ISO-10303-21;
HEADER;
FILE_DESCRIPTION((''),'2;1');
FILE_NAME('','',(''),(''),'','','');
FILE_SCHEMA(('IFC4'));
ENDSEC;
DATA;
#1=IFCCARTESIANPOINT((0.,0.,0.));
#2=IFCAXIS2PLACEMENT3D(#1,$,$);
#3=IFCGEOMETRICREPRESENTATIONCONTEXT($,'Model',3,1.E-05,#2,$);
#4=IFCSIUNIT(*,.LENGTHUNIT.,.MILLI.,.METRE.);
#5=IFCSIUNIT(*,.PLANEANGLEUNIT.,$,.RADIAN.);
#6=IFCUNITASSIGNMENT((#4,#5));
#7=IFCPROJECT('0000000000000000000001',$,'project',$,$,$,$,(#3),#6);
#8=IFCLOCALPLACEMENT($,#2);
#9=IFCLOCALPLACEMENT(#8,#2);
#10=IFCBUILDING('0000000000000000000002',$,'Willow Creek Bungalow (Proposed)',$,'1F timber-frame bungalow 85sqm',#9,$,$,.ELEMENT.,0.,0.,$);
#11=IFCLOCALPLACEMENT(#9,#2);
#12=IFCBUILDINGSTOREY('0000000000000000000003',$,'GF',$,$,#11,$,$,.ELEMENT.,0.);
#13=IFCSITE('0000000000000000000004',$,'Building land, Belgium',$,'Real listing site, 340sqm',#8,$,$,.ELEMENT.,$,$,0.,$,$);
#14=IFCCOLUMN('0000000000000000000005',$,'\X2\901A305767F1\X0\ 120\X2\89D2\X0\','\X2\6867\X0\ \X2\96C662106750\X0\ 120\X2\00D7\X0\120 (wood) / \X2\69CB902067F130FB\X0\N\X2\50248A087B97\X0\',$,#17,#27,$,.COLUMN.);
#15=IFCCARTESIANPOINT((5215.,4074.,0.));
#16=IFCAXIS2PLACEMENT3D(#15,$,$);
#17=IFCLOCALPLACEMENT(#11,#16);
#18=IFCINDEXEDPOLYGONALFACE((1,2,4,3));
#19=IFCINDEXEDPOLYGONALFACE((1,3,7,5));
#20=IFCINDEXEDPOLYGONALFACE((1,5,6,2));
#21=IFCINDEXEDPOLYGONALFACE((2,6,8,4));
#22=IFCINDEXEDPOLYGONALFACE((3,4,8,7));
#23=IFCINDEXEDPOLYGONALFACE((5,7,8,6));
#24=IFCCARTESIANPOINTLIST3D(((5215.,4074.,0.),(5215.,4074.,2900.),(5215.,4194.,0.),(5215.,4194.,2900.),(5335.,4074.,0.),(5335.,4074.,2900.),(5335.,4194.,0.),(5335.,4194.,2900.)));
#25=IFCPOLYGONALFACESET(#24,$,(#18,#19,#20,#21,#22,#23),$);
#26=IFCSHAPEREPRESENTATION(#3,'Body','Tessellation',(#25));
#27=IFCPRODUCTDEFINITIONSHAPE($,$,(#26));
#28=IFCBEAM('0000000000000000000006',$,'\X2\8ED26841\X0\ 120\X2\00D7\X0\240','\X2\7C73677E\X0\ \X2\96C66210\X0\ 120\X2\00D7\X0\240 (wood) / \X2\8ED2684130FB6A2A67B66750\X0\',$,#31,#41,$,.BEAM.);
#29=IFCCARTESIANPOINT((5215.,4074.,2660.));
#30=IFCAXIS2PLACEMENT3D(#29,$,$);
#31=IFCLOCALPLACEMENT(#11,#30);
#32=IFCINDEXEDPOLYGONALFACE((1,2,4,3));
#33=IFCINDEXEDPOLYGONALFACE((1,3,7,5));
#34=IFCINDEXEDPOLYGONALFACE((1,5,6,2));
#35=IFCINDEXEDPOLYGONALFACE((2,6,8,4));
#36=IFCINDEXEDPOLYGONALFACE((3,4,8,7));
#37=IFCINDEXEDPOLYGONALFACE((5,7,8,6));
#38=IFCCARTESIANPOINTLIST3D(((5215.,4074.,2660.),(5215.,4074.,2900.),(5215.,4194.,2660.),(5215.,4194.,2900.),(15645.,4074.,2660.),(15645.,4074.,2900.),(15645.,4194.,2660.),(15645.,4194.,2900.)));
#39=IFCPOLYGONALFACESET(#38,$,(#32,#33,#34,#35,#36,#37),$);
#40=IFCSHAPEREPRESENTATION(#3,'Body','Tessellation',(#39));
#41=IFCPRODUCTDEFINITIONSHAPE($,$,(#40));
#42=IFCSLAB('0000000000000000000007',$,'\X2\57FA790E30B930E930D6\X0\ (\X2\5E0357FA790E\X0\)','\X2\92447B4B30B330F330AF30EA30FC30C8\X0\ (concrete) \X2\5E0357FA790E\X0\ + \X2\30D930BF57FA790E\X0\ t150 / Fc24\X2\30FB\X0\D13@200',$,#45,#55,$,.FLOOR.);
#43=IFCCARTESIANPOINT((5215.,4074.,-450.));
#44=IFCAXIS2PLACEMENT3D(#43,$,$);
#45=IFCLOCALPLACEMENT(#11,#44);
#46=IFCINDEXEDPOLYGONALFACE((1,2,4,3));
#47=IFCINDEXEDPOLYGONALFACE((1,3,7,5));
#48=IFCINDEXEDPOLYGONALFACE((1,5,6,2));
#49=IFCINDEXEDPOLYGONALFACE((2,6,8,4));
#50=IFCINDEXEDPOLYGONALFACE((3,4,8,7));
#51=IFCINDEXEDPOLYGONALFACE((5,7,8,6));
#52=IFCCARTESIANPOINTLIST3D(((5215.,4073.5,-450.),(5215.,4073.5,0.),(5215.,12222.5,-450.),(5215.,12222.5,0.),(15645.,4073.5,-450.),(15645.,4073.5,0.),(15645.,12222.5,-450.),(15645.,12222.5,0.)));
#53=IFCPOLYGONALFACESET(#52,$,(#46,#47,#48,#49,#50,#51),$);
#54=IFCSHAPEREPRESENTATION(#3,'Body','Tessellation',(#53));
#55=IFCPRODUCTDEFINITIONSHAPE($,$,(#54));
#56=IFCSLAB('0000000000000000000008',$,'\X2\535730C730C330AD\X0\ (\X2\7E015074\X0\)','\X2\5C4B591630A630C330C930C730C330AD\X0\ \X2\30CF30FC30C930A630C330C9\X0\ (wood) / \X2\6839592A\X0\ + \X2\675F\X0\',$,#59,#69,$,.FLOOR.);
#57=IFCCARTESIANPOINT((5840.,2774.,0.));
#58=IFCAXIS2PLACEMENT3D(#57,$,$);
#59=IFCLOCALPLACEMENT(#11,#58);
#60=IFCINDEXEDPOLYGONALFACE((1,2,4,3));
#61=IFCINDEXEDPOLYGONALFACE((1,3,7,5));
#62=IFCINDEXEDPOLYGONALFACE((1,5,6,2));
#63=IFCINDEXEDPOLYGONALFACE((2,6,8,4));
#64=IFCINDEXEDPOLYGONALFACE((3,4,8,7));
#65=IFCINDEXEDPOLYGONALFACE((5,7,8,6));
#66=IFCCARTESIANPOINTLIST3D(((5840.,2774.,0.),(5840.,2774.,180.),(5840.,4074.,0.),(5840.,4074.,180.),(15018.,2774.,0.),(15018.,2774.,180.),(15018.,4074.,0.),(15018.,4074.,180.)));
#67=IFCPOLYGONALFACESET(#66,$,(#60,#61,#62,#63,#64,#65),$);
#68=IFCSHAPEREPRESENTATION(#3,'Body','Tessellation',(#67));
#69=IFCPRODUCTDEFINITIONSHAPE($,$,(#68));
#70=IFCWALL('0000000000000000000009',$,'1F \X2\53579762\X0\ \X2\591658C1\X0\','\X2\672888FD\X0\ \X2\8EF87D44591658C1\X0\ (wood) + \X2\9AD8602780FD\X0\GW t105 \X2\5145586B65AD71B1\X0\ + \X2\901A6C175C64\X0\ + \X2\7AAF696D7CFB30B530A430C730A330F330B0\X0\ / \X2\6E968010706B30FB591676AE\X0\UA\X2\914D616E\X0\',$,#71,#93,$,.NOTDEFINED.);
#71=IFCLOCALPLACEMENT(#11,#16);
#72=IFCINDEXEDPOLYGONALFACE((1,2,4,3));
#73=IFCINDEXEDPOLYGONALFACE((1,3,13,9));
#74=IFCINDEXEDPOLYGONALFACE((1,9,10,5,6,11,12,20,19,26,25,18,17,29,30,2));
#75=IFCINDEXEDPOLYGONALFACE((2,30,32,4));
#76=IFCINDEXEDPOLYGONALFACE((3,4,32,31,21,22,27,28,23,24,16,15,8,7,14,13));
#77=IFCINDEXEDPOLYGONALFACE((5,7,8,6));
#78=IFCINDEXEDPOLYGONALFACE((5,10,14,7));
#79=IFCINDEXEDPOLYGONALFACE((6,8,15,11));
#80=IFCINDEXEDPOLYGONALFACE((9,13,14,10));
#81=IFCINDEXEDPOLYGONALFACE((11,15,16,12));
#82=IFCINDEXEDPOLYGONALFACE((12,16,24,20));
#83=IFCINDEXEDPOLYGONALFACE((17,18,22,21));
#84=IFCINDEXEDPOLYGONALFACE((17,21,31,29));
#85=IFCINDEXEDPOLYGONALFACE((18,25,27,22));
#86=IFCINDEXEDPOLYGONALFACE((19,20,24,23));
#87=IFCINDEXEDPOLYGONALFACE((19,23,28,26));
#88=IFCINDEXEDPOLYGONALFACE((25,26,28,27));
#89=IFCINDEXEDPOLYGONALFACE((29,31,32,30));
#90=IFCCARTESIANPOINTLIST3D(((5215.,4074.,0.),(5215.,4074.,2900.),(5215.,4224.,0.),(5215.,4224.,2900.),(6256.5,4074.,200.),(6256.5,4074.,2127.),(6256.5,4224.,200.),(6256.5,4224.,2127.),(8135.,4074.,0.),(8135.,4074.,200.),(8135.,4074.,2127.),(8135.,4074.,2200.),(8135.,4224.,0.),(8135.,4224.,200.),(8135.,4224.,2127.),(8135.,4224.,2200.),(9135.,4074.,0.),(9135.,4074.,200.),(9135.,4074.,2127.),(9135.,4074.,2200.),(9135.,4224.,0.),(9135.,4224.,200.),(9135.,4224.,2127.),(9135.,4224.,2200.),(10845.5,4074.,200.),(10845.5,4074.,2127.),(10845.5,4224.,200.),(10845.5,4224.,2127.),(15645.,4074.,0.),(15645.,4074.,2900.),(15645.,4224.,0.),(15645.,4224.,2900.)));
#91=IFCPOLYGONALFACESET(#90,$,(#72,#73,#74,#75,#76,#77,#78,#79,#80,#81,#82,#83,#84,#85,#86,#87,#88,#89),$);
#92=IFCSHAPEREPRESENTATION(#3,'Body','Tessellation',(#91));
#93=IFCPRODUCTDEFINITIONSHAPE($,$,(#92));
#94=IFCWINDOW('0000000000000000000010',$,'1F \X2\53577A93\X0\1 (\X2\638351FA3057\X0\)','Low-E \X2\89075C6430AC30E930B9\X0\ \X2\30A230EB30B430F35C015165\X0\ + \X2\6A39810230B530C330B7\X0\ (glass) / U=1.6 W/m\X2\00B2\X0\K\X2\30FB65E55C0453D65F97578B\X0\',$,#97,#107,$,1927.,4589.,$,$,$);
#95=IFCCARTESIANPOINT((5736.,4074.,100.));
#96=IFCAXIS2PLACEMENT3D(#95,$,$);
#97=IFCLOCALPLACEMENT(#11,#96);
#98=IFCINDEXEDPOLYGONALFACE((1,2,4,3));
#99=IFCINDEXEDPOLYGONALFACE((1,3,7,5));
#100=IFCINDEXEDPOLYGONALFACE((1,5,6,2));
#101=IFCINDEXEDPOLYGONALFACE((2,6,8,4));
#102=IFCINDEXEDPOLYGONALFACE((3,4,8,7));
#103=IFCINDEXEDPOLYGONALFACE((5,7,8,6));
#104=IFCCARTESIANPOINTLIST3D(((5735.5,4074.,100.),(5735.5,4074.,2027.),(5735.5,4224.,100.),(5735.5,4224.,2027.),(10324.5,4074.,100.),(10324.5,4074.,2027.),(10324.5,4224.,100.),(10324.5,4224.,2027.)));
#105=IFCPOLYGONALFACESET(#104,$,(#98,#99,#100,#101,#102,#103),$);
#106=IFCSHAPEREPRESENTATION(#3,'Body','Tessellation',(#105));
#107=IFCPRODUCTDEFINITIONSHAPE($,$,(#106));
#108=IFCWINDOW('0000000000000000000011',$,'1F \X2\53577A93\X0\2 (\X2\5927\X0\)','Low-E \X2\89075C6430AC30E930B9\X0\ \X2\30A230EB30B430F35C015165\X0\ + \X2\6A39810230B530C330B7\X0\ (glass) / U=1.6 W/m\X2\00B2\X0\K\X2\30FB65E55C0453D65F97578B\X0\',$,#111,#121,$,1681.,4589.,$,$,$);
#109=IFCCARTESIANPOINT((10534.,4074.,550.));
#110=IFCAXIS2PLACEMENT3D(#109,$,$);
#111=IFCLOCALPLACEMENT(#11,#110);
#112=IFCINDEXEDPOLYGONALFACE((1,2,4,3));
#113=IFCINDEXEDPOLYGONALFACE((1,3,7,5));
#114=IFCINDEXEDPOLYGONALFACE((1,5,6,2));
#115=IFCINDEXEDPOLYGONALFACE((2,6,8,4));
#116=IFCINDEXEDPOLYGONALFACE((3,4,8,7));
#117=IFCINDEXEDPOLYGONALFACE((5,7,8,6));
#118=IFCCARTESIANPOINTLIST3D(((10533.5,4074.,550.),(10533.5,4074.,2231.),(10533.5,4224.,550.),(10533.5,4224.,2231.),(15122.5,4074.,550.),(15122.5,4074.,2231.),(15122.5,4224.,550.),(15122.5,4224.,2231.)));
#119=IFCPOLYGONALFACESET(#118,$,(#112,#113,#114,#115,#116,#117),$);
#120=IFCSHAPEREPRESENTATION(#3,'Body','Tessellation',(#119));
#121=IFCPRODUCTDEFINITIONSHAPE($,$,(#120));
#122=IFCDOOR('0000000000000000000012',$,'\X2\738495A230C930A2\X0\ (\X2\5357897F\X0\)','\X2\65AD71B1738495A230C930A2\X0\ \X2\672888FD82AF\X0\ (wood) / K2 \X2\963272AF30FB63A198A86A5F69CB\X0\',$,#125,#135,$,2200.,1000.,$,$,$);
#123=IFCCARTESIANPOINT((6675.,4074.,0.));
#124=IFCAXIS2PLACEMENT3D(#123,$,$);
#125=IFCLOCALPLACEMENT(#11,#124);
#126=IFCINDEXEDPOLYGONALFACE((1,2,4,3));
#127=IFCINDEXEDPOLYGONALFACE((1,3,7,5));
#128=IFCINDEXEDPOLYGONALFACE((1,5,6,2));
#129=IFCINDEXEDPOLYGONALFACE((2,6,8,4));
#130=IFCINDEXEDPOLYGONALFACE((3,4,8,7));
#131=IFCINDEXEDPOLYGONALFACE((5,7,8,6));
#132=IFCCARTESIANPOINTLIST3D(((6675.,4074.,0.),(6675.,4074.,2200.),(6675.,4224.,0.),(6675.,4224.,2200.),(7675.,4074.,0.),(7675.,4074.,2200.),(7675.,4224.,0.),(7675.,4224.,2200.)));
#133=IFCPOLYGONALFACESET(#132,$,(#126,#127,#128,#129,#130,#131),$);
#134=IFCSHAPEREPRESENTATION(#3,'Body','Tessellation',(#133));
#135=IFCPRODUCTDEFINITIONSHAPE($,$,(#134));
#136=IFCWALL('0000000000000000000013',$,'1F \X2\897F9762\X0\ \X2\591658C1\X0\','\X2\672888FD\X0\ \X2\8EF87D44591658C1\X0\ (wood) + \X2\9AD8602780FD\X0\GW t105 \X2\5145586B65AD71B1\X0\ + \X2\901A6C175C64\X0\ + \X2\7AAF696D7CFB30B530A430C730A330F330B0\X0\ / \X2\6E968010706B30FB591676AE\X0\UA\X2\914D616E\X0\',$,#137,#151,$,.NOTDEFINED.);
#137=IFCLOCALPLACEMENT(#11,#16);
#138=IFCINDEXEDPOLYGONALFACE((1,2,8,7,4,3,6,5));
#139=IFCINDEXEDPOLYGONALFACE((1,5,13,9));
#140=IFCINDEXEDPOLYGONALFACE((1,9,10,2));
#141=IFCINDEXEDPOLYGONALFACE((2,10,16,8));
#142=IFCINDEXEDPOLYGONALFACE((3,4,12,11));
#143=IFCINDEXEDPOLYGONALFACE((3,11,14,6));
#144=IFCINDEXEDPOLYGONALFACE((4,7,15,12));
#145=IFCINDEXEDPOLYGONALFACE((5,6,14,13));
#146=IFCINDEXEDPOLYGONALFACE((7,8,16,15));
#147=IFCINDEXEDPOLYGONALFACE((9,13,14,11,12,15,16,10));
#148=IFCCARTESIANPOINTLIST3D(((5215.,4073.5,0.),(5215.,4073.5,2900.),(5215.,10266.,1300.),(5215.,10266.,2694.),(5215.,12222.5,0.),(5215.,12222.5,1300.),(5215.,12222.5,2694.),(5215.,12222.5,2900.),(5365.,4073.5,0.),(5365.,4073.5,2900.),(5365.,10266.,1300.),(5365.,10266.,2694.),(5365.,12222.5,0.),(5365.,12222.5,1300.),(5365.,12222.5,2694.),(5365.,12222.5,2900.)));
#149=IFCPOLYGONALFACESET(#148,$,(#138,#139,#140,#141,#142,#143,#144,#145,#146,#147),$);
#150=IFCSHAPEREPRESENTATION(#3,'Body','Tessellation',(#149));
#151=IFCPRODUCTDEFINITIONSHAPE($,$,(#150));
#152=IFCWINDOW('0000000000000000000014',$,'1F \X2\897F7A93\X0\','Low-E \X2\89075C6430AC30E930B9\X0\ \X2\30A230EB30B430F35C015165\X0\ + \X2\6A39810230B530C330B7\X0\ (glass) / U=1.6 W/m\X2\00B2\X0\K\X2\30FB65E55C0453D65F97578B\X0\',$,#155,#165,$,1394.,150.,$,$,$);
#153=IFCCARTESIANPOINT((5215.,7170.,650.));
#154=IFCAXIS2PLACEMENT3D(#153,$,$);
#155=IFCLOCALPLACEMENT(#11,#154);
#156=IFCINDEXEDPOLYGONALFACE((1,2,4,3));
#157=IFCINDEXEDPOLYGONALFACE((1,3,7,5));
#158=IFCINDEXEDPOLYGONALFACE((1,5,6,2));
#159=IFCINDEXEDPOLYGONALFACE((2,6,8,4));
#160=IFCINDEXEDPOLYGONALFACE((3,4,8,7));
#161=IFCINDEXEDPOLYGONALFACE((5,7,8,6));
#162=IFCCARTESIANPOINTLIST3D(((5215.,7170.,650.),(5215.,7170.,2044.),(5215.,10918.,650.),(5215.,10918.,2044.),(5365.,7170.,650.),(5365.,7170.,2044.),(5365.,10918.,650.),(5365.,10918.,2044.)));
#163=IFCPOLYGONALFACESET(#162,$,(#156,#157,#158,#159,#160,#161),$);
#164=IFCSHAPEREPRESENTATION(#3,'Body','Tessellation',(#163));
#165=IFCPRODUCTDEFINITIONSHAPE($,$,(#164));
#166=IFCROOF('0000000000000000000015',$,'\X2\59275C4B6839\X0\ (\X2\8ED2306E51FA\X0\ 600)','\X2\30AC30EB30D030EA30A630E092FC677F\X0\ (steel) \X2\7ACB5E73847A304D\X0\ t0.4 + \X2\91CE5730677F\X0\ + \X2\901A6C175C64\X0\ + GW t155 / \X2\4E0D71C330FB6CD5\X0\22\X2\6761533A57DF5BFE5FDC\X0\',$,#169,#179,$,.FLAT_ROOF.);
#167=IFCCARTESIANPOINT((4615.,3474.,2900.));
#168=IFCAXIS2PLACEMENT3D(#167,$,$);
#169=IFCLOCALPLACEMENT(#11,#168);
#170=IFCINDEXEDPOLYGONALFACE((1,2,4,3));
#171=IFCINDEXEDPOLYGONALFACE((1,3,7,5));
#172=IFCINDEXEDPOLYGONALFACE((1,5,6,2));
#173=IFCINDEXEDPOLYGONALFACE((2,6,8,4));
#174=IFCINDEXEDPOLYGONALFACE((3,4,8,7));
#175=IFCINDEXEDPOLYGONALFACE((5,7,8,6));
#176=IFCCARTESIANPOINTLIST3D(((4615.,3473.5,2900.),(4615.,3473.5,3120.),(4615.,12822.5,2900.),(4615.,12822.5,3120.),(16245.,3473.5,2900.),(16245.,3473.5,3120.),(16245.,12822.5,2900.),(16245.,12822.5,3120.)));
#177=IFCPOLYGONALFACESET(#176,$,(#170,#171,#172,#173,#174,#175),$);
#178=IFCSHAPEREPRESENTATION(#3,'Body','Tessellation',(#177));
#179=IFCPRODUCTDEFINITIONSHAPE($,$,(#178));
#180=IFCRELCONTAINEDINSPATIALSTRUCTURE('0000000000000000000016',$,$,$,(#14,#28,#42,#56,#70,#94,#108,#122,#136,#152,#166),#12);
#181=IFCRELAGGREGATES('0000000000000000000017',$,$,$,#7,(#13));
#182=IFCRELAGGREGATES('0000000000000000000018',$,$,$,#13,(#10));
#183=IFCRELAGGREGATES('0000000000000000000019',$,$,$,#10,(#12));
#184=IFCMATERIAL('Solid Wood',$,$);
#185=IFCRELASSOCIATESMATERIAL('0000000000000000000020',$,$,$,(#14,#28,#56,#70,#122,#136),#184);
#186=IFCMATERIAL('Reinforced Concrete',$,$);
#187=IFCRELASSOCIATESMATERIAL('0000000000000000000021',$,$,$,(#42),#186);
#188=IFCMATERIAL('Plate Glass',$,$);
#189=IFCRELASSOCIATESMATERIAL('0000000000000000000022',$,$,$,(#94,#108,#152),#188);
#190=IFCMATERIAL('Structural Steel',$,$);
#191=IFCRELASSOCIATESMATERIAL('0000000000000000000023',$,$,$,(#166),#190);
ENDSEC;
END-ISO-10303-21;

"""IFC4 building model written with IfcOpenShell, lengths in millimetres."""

from ifc_helpers import new_model, si_unit, frame, frame_2d, origin, place, context, project, spatial, rectangle, extrude, material, element, fill, save


model = new_model("IFC4")

# Units and contexts
model_context = context("Model", 3, precision=1e-05, world=origin())
ifc_project = project(units=[si_unit("LENGTHUNIT", "METRE", prefix="MILLI"), si_unit("PLANEANGLEUNIT", "RADIAN")], contexts=[model_context])

# Site, building, storey
site_placement = place(None, origin())
site = spatial("IfcSite", under=ifc_project, at=site_placement, Name="Building land, Belgium", ObjectType="Real listing site, 340sqm", CompositionType="ELEMENT", RefElevation=0.0)
building_placement = place(site_placement, origin())
building = spatial("IfcBuilding", under=site, at=building_placement, Name="Willow Creek Bungalow (Proposed)", ObjectType="1F timber-frame bungalow 85sqm", CompositionType="ELEMENT", ElevationOfRefHeight=0.0, ElevationOfTerrain=0.0)
storey_placement = place(building_placement, origin())
storey = spatial("IfcBuildingStorey", under=building, at=storey_placement, Name="GF", CompositionType="ELEMENT", Elevation=0.0)

# Column
ifc_material_1 = material(Name="Solid Wood")
column_1_placement = place(storey_placement, frame((5215.0, 4074.0, 0.0)))
element("IfcColumn", 1, at=column_1_placement, inside=storey, material=ifc_material_1, Name="通し柱 120角", Description="桧 集成材 120×120 (wood) / 構造柱・N値計算", PredefinedType="COLUMN", context=model_context, shape_type="SweptSolid", body=[
    extrude(rectangle(XDim=120.0, YDim=120.0, at=frame_2d((60.0, 60.0))), frame((5215.0, 4074.0, 0.0)), (0.0, 0.0, 1.0), 2900.0),
])

# Beam
beam_1_placement = place(storey_placement, frame((5215.0, 4074.0, 2660.0)))
element("IfcBeam", 2, at=beam_1_placement, inside=storey, material=ifc_material_1, Name="軒桁 120×240", Description="米松 集成 120×240 (wood) / 軒桁・横架材", PredefinedType="BEAM", context=model_context, shape_type="SweptSolid", body=[
    extrude(rectangle(XDim=10430.0, YDim=120.0, at=frame_2d((5215.0, 60.0))), frame((5215.0, 4074.0, 2660.0)), (0.0, 0.0, 1.0), 240.0),
])

# Slabs
ifc_material_2 = material(Name="Reinforced Concrete")
slab_1_placement = place(storey_placement, frame((5215.0, 4074.0, -450.0)))
element("IfcSlab", 3, at=slab_1_placement, inside=storey, material=ifc_material_2, Name="基礎スラブ (布基礎)", Description="鉄筋コンクリート (concrete) 布基礎 + ベタ基礎 t150 / Fc24・D13@200", PredefinedType="FLOOR", context=model_context, shape_type="SweptSolid", body=[
    extrude(rectangle(XDim=10430.0, YDim=8149.0, at=frame_2d((5215.0, 4074.0))), frame((5215.0, 4074.0, -450.0)), (0.0, 0.0, 1.0), 450.0),
])
slab_2_placement = place(storey_placement, frame((5840.0, 2774.0, 0.0)))
element("IfcSlab", 4, at=slab_2_placement, inside=storey, material=ifc_material_1, Name="南デッキ (縁側)", Description="屋外ウッドデッキ ハードウッド (wood) / 根太 + 束", PredefinedType="FLOOR", context=model_context, shape_type="SweptSolid", body=[
    extrude(rectangle(XDim=9178.0, YDim=1300.0, at=frame_2d((4589.0, 650.0))), frame((5840.0, 2774.0, 0.0)), (0.0, 0.0, 1.0), 180.0),
])

# Wall, openings, windows, door
wall_1_placement = place(storey_placement, frame((5215.0, 4074.0, 0.0)))
wall_1 = element("IfcWall", 5, at=wall_1_placement, inside=storey, material=ifc_material_1, Name="1F 南面 外壁", Description="木製 軸組外壁 (wood) + 高性能GW t105 充填断熱 + 通気層 + 窯業系サイディング / 準耐火・外皮UA配慮", PredefinedType="NOTDEFINED", context=model_context, shape_type="SweptSolid", body=[
    extrude(rectangle(XDim=10430.0, YDim=150.0, at=frame_2d((5215.0, 75.0))), frame((5215.0, 4074.0, 0.0)), (0.0, 0.0, 1.0), 2900.0),
])
opening_1_placement = place(storey_placement, frame((5736.0, 4074.0, 100.0)))
opening_1 = element("IfcOpeningElement", 6, at=opening_1_placement, cuts=wall_1, PredefinedType="NOTDEFINED", context=model_context, shape_type="SweptSolid", body=[
    extrude(rectangle(XDim=4589.0, YDim=150.0, at=frame_2d((2294.0, 75.0))), frame((5736.0, 4074.0, 100.0)), (0.0, 0.0, 1.0), 1927.0),
])
opening_2_placement = place(storey_placement, frame((10534.0, 4074.0, 550.0)))
opening_2 = element("IfcOpeningElement", 7, at=opening_2_placement, cuts=wall_1, PredefinedType="NOTDEFINED", context=model_context, shape_type="SweptSolid", body=[
    extrude(rectangle(XDim=4589.0, YDim=150.0, at=frame_2d((2294.0, 75.0))), frame((10534.0, 4074.0, 550.0)), (0.0, 0.0, 1.0), 1681.0),
])
opening_3_placement = place(storey_placement, frame((6675.0, 4074.0, 0.0)))
opening_3 = element("IfcOpeningElement", 8, at=opening_3_placement, cuts=wall_1, PredefinedType="NOTDEFINED", context=model_context, shape_type="SweptSolid", body=[
    extrude(rectangle(XDim=1000.0, YDim=150.0, at=frame_2d((500.0, 75.0))), frame((6675.0, 4074.0, 0.0)), (0.0, 0.0, 1.0), 2200.0),
])
ifc_material_3 = material(Name="Plate Glass")
window_1_placement = place(storey_placement, frame((5736.0, 4074.0, 100.0)))
window_1 = element("IfcWindow", 9, at=window_1_placement, inside=storey, material=ifc_material_3, Name="1F 南窓1 (掃出し)", Description="Low-E 複層ガラス アルゴン封入 + 樹脂サッシ (glass) / U=1.6 W/m²K・日射取得型", OverallHeight=1927.0, OverallWidth=4589.0, context=model_context, shape_type="SweptSolid", body=[
    extrude(rectangle(XDim=4589.0, YDim=150.0, at=frame_2d((2294.0, 75.0))), frame((5736.0, 4074.0, 100.0)), (0.0, 0.0, 1.0), 1927.0),
])
fill(opening_1, window_1)
window_2_placement = place(storey_placement, frame((10534.0, 4074.0, 550.0)))
window_2 = element("IfcWindow", 10, at=window_2_placement, inside=storey, material=ifc_material_3, Name="1F 南窓2 (大)", Description="Low-E 複層ガラス アルゴン封入 + 樹脂サッシ (glass) / U=1.6 W/m²K・日射取得型", OverallHeight=1681.0, OverallWidth=4589.0, context=model_context, shape_type="SweptSolid", body=[
    extrude(rectangle(XDim=4589.0, YDim=150.0, at=frame_2d((2294.0, 75.0))), frame((10534.0, 4074.0, 550.0)), (0.0, 0.0, 1.0), 1681.0),
])
fill(opening_2, window_2)
door_placement = place(storey_placement, frame((6675.0, 4074.0, 0.0)))
door = element("IfcDoor", 11, at=door_placement, inside=storey, material=ifc_material_1, Name="玄関ドア (南西)", Description="断熱玄関ドア 木製芯 (wood) / K2 防犯・採風機構", OverallHeight=2200.0, OverallWidth=1000.0, context=model_context, shape_type="SweptSolid", body=[
    extrude(rectangle(XDim=1000.0, YDim=150.0, at=frame_2d((500.0, 75.0))), frame((6675.0, 4074.0, 0.0)), (0.0, 0.0, 1.0), 2200.0),
])
fill(opening_3, door)

# Wall, opening, window
wall_2_placement = place(storey_placement, frame((5215.0, 4074.0, 0.0)))
wall_2 = element("IfcWall", 12, at=wall_2_placement, inside=storey, material=ifc_material_1, Name="1F 西面 外壁", Description="木製 軸組外壁 (wood) + 高性能GW t105 充填断熱 + 通気層 + 窯業系サイディング / 準耐火・外皮UA配慮", PredefinedType="NOTDEFINED", context=model_context, shape_type="SweptSolid", body=[
    extrude(rectangle(XDim=150.0, YDim=8149.0, at=frame_2d((75.0, 4074.0))), frame((5215.0, 4074.0, 0.0)), (0.0, 0.0, 1.0), 2900.0),
])
opening_4_placement = place(storey_placement, frame((5215.0, 7170.0, 650.0)))
opening_4 = element("IfcOpeningElement", 13, at=opening_4_placement, cuts=wall_2, PredefinedType="NOTDEFINED", context=model_context, shape_type="SweptSolid", body=[
    extrude(rectangle(XDim=150.0, YDim=3748.0, at=frame_2d((75.0, 1874.0))), frame((5215.0, 7170.0, 650.0)), (0.0, 0.0, 1.0), 1394.0),
])
window_3_placement = place(storey_placement, frame((5215.0, 7170.0, 650.0)))
window_3 = element("IfcWindow", 14, at=window_3_placement, inside=storey, material=ifc_material_3, Name="1F 西窓", Description="Low-E 複層ガラス アルゴン封入 + 樹脂サッシ (glass) / U=1.6 W/m²K・日射取得型", OverallHeight=1394.0, OverallWidth=150.0, context=model_context, shape_type="SweptSolid", body=[
    extrude(rectangle(XDim=150.0, YDim=3748.0, at=frame_2d((75.0, 1874.0))), frame((5215.0, 7170.0, 650.0)), (0.0, 0.0, 1.0), 1394.0),
])
fill(opening_4, window_3)

# Roof
ifc_material_4 = material(Name="Structural Steel")
roof_placement = place(storey_placement, frame((4615.0, 3474.0, 2900.0)))
element("IfcRoof", 15, at=roof_placement, inside=storey, material=ifc_material_4, Name="大屋根 (軒の出 600)", Description="ガルバリウム鋼板 (steel) 立平葺き t0.4 + 野地板 + 通気層 + GW t155 / 不燃・法22条区域対応", PredefinedType="FLAT_ROOF", context=model_context, shape_type="SweptSolid", body=[
    extrude(rectangle(XDim=11630.0, YDim=9349.0, at=frame_2d((5815.0, 4674.0))), frame((4615.0, 3474.0, 2900.0)), (0.0, 0.0, 1.0), 220.0),
])

save(model, "model.ifc")
